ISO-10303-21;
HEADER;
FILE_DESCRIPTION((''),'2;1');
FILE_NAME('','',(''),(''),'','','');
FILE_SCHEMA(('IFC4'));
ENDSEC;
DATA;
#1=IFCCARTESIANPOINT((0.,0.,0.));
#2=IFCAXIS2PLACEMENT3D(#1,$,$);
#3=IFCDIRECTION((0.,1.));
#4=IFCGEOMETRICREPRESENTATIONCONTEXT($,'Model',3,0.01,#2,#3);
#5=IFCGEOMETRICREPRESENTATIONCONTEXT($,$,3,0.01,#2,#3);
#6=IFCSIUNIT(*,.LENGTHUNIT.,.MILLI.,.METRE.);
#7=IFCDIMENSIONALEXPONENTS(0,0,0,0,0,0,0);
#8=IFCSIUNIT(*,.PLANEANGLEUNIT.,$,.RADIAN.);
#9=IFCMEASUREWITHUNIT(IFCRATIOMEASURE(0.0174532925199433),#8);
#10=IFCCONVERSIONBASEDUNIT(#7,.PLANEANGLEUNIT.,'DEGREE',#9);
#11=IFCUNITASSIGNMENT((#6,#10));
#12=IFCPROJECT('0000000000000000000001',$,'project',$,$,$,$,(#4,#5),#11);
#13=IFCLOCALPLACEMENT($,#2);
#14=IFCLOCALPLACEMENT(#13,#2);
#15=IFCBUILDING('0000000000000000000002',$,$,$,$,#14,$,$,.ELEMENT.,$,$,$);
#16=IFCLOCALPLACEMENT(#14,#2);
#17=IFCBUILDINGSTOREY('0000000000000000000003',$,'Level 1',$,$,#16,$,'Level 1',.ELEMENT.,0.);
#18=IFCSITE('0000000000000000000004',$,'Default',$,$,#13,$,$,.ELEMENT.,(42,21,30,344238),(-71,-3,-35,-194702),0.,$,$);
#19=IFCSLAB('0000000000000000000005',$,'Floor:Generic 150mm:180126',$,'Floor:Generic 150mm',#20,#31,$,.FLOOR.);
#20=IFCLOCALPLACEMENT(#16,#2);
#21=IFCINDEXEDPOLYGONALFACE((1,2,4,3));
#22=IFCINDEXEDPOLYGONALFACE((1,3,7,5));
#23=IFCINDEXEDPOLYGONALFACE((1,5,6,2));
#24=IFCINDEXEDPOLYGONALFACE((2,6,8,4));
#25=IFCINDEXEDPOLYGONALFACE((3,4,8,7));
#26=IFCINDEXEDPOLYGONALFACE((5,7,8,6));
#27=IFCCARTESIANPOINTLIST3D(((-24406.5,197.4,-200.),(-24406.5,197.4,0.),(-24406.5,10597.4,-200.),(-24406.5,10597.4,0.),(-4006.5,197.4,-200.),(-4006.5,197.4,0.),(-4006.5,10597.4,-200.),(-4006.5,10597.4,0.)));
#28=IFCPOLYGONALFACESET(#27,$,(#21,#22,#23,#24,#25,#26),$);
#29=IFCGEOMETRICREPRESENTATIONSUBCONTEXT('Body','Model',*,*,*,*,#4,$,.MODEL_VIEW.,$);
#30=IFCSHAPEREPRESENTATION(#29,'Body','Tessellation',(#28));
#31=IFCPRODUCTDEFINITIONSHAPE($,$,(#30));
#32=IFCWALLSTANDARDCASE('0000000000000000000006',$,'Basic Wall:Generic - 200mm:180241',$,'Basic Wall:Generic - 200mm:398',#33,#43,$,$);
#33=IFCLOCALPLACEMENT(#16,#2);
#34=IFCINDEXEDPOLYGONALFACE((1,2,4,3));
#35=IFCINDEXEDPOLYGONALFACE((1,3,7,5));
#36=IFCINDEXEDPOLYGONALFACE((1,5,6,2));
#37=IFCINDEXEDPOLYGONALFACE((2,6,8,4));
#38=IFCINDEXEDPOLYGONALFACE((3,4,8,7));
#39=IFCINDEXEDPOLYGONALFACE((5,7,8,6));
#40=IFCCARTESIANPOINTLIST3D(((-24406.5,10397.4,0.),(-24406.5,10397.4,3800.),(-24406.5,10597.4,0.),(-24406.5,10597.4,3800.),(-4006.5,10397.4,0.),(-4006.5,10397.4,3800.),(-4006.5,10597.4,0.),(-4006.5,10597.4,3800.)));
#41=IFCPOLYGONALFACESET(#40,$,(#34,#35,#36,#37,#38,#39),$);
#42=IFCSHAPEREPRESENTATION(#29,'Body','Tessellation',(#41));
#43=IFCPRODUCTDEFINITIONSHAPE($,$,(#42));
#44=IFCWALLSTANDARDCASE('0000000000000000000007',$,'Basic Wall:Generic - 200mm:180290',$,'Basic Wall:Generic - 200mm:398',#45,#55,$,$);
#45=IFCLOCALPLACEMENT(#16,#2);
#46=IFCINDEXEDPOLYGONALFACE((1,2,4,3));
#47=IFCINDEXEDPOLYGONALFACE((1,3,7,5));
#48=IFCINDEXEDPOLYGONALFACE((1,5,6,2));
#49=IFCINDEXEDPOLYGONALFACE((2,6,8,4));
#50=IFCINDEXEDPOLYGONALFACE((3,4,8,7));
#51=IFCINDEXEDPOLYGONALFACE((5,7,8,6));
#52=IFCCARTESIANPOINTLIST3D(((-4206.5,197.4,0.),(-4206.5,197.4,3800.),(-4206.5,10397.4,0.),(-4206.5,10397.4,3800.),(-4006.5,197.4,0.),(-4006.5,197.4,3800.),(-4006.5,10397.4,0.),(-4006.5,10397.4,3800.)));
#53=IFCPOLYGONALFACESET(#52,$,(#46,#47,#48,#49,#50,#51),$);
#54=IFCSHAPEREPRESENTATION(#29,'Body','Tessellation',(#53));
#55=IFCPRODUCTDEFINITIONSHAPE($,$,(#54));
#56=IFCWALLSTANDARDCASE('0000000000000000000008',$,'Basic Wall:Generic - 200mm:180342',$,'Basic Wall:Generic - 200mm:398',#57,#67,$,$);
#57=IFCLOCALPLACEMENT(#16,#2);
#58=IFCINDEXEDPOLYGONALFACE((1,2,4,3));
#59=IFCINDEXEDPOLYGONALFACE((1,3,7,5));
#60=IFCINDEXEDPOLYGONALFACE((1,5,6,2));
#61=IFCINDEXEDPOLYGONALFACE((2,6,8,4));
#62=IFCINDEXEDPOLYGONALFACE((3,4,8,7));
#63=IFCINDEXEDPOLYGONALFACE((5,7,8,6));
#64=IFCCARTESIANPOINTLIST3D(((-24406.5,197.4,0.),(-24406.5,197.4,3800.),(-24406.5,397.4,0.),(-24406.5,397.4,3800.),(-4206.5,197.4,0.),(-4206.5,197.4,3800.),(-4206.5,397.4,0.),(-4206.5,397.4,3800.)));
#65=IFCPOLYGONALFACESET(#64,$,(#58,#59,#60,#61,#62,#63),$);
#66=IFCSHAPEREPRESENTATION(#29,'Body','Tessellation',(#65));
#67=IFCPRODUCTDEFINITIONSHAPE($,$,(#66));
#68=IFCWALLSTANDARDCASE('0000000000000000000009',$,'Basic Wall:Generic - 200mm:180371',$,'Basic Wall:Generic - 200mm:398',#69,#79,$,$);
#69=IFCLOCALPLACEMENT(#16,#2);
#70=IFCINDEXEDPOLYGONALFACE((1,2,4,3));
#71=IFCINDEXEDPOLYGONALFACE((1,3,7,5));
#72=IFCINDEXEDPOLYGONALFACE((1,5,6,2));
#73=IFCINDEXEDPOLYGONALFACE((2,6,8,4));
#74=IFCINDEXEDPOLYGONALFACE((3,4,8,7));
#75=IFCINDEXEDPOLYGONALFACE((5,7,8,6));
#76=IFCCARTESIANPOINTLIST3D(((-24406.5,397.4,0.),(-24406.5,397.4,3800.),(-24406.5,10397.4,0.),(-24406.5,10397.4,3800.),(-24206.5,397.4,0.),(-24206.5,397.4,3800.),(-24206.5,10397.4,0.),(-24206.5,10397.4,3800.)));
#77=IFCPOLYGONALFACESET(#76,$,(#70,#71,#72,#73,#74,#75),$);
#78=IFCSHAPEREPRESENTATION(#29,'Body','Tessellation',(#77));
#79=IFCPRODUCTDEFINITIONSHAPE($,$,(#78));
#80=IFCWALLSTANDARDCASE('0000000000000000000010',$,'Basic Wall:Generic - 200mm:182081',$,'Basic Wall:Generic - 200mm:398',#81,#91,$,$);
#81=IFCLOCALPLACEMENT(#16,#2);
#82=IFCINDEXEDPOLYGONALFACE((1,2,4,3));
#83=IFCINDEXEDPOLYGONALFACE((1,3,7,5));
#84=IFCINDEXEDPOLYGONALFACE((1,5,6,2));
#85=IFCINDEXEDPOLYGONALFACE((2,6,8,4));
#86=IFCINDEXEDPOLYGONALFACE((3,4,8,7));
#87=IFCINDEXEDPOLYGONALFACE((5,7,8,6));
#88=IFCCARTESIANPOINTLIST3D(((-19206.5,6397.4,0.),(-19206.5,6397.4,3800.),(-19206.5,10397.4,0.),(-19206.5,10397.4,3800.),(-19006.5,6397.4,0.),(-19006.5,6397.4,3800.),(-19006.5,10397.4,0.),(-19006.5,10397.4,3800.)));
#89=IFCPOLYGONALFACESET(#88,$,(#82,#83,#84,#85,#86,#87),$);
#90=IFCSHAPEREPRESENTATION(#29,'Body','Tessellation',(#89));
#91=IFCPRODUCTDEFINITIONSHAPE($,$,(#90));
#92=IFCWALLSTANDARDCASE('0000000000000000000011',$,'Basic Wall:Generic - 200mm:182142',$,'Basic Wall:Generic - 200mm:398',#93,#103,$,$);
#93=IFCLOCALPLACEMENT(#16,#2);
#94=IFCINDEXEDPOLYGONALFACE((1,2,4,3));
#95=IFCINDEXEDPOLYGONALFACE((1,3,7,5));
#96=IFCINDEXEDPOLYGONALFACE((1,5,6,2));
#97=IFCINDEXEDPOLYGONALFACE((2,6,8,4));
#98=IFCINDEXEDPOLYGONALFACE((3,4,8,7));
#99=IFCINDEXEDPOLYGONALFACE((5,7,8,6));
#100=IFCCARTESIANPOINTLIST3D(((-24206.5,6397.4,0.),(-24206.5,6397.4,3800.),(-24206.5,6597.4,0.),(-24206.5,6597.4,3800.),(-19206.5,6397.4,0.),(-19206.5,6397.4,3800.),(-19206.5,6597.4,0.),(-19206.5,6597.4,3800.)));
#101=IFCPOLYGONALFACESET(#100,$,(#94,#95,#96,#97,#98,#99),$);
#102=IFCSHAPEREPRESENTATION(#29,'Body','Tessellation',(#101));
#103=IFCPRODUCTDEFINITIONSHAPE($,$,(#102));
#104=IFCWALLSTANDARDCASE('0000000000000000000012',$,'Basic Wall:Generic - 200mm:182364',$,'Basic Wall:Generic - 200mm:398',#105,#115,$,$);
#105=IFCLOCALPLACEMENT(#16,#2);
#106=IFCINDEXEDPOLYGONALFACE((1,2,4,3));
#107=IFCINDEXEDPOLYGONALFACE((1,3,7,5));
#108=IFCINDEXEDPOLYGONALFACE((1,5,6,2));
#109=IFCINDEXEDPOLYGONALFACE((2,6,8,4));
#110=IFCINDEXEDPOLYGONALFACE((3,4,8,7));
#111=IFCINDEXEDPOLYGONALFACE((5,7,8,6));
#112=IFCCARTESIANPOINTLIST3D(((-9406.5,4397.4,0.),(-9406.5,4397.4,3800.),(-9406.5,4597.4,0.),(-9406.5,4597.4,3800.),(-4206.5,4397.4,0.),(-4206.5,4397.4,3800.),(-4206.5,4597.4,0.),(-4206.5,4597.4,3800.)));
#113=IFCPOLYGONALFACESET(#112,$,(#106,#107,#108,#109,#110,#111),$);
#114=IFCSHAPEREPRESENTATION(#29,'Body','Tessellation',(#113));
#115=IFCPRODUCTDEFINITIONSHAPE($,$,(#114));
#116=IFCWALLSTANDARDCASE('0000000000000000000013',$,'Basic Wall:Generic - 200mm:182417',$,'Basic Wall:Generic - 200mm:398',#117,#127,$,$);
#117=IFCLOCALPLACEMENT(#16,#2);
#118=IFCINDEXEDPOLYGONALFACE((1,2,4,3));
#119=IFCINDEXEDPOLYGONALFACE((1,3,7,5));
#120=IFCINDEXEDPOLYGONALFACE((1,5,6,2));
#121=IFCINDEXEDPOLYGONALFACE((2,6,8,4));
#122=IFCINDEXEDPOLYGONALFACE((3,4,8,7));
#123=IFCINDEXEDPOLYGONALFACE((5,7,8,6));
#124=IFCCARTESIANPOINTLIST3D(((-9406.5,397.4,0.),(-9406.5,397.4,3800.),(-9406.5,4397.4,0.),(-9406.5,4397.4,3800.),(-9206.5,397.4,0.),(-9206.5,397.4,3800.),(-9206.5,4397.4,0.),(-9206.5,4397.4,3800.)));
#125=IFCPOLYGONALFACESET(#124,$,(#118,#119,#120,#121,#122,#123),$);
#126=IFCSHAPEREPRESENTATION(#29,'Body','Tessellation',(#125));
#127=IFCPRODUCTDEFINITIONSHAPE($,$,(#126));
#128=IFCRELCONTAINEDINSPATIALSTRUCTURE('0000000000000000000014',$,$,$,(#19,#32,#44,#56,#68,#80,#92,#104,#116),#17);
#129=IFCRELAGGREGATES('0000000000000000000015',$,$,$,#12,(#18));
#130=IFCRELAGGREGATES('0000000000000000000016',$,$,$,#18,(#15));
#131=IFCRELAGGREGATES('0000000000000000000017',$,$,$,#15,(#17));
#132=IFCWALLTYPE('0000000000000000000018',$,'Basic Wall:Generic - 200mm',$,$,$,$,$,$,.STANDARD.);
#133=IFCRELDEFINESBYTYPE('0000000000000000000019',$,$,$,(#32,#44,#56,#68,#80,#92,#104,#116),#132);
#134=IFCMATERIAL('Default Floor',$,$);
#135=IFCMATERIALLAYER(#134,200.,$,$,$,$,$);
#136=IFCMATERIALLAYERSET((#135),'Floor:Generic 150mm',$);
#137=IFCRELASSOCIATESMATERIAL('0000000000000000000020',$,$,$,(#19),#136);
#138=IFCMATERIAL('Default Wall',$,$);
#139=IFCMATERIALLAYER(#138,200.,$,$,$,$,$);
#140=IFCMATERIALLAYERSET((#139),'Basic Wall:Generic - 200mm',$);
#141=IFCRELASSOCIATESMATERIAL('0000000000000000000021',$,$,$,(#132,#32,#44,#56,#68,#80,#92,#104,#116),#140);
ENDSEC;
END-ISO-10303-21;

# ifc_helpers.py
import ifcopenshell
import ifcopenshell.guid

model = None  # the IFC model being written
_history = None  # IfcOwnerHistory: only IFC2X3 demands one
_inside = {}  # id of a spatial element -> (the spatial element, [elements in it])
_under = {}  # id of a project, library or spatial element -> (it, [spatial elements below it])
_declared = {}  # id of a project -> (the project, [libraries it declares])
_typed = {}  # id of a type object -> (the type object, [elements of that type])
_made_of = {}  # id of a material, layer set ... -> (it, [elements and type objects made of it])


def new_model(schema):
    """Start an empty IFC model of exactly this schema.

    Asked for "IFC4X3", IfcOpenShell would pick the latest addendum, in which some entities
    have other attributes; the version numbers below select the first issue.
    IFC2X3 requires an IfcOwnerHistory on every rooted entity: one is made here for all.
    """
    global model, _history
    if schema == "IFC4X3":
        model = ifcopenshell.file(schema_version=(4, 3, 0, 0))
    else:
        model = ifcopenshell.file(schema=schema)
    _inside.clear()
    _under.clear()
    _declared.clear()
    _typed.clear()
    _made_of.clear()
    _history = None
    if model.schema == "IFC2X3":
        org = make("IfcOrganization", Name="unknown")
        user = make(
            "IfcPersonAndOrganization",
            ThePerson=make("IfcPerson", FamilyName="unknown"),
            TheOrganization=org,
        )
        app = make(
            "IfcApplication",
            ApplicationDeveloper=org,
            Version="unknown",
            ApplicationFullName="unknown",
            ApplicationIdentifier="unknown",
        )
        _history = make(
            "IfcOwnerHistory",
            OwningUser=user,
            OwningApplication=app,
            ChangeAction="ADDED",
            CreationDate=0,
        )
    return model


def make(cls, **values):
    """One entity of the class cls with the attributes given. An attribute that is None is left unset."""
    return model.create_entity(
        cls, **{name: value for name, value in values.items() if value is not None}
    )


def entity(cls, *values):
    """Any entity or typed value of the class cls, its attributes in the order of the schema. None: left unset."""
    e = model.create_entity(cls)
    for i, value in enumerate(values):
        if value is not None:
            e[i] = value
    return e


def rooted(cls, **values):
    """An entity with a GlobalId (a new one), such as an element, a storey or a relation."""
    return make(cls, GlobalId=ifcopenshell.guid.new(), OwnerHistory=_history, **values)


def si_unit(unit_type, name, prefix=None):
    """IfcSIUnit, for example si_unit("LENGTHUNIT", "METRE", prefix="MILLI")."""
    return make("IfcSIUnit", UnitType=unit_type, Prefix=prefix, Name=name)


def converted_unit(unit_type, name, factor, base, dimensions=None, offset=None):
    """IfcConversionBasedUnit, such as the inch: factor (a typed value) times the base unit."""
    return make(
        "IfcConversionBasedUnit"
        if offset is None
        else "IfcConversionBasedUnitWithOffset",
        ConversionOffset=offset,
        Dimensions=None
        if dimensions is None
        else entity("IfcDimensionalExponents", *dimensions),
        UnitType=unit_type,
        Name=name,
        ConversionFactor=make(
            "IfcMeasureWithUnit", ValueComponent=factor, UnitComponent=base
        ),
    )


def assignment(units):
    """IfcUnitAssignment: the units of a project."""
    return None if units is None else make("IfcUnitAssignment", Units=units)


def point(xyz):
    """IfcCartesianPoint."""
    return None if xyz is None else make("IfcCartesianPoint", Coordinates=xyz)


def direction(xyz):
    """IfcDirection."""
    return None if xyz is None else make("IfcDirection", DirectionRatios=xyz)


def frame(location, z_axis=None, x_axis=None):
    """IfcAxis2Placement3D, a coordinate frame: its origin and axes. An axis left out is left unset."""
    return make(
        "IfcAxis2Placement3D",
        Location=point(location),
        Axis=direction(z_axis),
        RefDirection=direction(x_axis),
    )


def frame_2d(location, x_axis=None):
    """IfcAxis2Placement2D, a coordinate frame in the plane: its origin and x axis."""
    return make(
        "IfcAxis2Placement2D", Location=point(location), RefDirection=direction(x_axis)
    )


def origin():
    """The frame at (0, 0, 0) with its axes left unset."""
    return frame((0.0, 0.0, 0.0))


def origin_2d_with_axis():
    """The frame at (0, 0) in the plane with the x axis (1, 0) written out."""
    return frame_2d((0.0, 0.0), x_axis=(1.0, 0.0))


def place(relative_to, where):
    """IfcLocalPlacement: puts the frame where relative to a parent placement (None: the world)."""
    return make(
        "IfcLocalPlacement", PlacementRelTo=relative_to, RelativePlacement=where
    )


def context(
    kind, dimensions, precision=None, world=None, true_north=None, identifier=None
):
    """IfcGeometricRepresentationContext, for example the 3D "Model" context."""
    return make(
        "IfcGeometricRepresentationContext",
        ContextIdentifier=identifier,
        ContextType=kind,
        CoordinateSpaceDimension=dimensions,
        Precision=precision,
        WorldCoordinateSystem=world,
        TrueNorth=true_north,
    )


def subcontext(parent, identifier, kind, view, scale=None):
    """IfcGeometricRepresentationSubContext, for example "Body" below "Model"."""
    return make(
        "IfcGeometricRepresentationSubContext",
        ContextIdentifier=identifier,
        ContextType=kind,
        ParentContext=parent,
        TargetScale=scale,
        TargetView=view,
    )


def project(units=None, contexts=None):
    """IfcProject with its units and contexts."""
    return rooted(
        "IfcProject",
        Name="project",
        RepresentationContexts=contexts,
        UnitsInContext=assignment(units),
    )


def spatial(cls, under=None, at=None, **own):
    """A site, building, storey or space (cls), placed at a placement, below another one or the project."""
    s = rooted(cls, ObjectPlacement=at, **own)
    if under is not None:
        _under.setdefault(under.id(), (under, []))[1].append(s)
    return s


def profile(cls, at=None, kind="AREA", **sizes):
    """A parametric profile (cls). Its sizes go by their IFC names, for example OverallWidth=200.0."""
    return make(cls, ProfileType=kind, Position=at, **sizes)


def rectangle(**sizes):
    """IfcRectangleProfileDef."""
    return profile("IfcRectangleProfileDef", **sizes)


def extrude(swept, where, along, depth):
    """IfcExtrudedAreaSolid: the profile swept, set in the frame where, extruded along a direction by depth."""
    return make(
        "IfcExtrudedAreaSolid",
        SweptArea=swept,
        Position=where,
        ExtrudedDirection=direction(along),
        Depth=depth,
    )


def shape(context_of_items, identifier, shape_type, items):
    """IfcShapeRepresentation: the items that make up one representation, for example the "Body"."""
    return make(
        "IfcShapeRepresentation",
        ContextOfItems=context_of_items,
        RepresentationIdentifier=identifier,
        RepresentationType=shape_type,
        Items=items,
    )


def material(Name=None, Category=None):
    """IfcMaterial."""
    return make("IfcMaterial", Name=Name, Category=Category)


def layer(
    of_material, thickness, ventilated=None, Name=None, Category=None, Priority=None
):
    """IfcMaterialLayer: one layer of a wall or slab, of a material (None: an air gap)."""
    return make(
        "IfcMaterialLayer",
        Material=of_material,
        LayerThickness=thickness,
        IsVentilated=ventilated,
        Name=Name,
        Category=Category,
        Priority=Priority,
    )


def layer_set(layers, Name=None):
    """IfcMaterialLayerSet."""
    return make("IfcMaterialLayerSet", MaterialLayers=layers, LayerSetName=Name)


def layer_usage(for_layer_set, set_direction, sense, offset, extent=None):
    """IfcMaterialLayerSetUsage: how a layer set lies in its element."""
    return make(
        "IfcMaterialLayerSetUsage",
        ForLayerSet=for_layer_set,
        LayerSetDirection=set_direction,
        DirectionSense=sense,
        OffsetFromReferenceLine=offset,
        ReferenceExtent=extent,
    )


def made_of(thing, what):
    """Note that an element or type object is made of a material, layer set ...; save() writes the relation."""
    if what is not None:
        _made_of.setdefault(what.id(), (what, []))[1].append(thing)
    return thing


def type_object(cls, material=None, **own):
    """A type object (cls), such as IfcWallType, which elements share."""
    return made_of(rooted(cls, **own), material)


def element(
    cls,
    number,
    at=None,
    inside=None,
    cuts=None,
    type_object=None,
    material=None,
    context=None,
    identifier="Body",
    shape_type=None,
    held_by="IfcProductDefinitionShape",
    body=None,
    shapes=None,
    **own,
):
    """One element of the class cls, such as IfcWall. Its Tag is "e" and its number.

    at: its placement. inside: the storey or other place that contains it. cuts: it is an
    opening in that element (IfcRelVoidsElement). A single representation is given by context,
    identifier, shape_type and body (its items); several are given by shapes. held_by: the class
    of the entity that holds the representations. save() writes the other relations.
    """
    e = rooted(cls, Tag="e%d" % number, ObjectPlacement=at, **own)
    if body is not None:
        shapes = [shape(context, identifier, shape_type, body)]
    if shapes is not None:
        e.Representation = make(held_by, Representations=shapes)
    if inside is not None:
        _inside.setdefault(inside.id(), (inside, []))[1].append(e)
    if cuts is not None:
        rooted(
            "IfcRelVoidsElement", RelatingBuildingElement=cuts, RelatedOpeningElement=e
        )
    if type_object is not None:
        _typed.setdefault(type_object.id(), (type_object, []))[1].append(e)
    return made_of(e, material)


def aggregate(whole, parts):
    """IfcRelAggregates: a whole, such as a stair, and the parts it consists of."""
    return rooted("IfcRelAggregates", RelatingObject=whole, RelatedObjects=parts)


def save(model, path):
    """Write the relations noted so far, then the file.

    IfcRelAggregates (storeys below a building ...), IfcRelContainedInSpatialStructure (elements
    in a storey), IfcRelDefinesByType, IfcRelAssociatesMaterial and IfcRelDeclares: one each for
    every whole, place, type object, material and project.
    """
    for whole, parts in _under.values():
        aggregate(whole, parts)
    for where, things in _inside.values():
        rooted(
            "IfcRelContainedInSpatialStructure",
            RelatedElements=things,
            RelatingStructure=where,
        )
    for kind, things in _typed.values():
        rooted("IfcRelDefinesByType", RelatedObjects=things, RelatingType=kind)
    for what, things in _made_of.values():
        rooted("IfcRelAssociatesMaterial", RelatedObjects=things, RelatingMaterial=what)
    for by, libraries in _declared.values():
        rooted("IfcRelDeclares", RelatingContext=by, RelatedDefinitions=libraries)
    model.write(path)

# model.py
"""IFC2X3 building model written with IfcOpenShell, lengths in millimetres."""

from ifc_helpers import new_model, entity, si_unit, converted_unit, direction, frame, frame_2d, origin, origin_2d_with_axis, place, context, subcontext, project, spatial, rectangle, extrude, material, layer, layer_set, layer_usage, type_object, element, save


model = new_model("IFC2X3")

# Units and contexts
model_context = context("Model", 3, precision=0.01, world=origin(), true_north=direction((0.0, 1.0)))
context_of_model = context(None, 3, precision=0.01, world=origin(), true_north=direction((0.0, 1.0)))
body_context = subcontext(model_context, "Body", "Model", "MODEL_VIEW")
ifc_project = project(units=[si_unit("LENGTHUNIT", "METRE", prefix="MILLI"), converted_unit("PLANEANGLEUNIT", "DEGREE", entity("IfcRatioMeasure", 0.0174532925199433), si_unit("PLANEANGLEUNIT", "RADIAN"), dimensions=[0, 0, 0, 0, 0, 0, 0])], contexts=[model_context, context_of_model])

# Site, building, storey
site_placement = place(None, origin())
site = spatial("IfcSite", under=ifc_project, at=site_placement, Name="Default", CompositionType="ELEMENT", RefLatitude=(42, 21, 30, 344238), RefLongitude=(-71, -3, -35, -194702), RefElevation=0.0)
building_placement = place(site_placement, origin())
building = spatial("IfcBuilding", under=site, at=building_placement, CompositionType="ELEMENT")
storey_placement = place(building_placement, origin())
storey = spatial("IfcBuildingStorey", under=building, at=storey_placement, Name="Level 1", LongName="Level 1", CompositionType="ELEMENT", Elevation=0.0)

# Slab
ifc_material_1 = material(Name="Default Floor")
ifc_layer_1 = layer(ifc_material_1, 200.0)
ifc_layer_set_1 = layer_set([ifc_layer_1], Name="Floor:Generic 150mm")
ifc_layer_usage_1 = layer_usage(ifc_layer_set_1, "AXIS3", "POSITIVE", 0.0)
slab_placement = place(storey_placement, origin())
element("IfcSlab", 1, at=slab_placement, inside=storey, material=ifc_layer_usage_1, Name="Floor:Generic 150mm:180126", ObjectType="Floor:Generic 150mm", PredefinedType="FLOOR", context=body_context, shape_type="SweptSolid", body=[
    extrude(rectangle(XDim=10400.0, YDim=20400.0, at=origin_2d_with_axis()), frame((-14206.5, 5397.4, 0.0), z_axis=(0.0, 0.0, -1.0), x_axis=(0.0, 1.0, 0.0)), (0.0, 0.0, 1.0), 200.0),
])

# Walls
ifc_material_2 = material(Name="Default Wall")
ifc_layer_2 = layer(ifc_material_2, 200.0)
ifc_layer_set_2 = layer_set([ifc_layer_2], Name="Basic Wall:Generic - 200mm")
ifc_layer_usage_2 = layer_usage(ifc_layer_set_2, "AXIS2", "NEGATIVE", 100.0)
wall_type = type_object("IfcWallType", Name="Basic Wall:Generic - 200mm", PredefinedType="STANDARD", material=ifc_layer_set_2)
wall_1_placement = place(storey_placement, frame((-24406.5, 10497.4, 0.0)))
element("IfcWallStandardCase", 2, at=wall_1_placement, inside=storey, type_object=wall_type, material=ifc_layer_usage_2, Name="Basic Wall:Generic - 200mm:180241", ObjectType="Basic Wall:Generic - 200mm:398", context=body_context, shape_type="SweptSolid", body=[
    extrude(rectangle(XDim=20400.0, YDim=200.0, at=frame_2d((10200.0, 0.0), x_axis=(-1.0, 0.0))), origin(), (0.0, 0.0, 1.0), 3800.0),
])
ifc_layer_usage_3 = layer_usage(ifc_layer_set_2, "AXIS2", "NEGATIVE", 100.0)
wall_2_placement = place(storey_placement, frame((-4106.5, 10397.4, 0.0), z_axis=(0.0, 0.0, 1.0), x_axis=(0.0, -1.0, 0.0)))
element("IfcWallStandardCase", 3, at=wall_2_placement, inside=storey, type_object=wall_type, material=ifc_layer_usage_3, Name="Basic Wall:Generic - 200mm:180290", ObjectType="Basic Wall:Generic - 200mm:398", context=body_context, shape_type="SweptSolid", body=[
    extrude(rectangle(XDim=10200.0, YDim=200.0, at=frame_2d((5100.0, 0.0), x_axis=(-1.0, 0.0))), origin(), (0.0, 0.0, 1.0), 3800.0),
])
ifc_layer_usage_4 = layer_usage(ifc_layer_set_2, "AXIS2", "NEGATIVE", 100.0)
wall_3_placement = place(storey_placement, frame((-4206.5, 297.4, 0.0), z_axis=(0.0, 0.0, 1.0), x_axis=(-1.0, 0.0, 0.0)))
element("IfcWallStandardCase", 4, at=wall_3_placement, inside=storey, type_object=wall_type, material=ifc_layer_usage_4, Name="Basic Wall:Generic - 200mm:180342", ObjectType="Basic Wall:Generic - 200mm:398", context=body_context, shape_type="SweptSolid", body=[
    extrude(rectangle(XDim=20200.0, YDim=200.0, at=frame_2d((10100.0, 0.0), x_axis=(-1.0, 0.0))), origin(), (0.0, 0.0, 1.0), 3800.0),
])
ifc_layer_usage_5 = layer_usage(ifc_layer_set_2, "AXIS2", "NEGATIVE", 100.0)
wall_4_placement = place(storey_placement, frame((-24306.5, 397.4, 0.0), z_axis=(0.0, 0.0, 1.0), x_axis=(0.0, 1.0, 0.0)))
element("IfcWallStandardCase", 5, at=wall_4_placement, inside=storey, type_object=wall_type, material=ifc_layer_usage_5, Name="Basic Wall:Generic - 200mm:180371", ObjectType="Basic Wall:Generic - 200mm:398", context=body_context, shape_type="SweptSolid", body=[
    extrude(rectangle(XDim=10000.0, YDim=200.0, at=frame_2d((5000.0, 0.0), x_axis=(-1.0, 0.0))), origin(), (0.0, 0.0, 1.0), 3800.0),
])
ifc_layer_usage_6 = layer_usage(ifc_layer_set_2, "AXIS2", "NEGATIVE", 100.0)
wall_5_placement = place(storey_placement, frame((-19106.5, 10397.4, 0.0), z_axis=(0.0, 0.0, 1.0), x_axis=(0.0, -1.0, 0.0)))
element("IfcWallStandardCase", 6, at=wall_5_placement, inside=storey, type_object=wall_type, material=ifc_layer_usage_6, Name="Basic Wall:Generic - 200mm:182081", ObjectType="Basic Wall:Generic - 200mm:398", context=body_context, shape_type="SweptSolid", body=[
    extrude(rectangle(XDim=4000.0, YDim=200.0, at=frame_2d((2000.0, 0.0), x_axis=(-1.0, 0.0))), origin(), (0.0, 0.0, 1.0), 3800.0),
])
ifc_layer_usage_7 = layer_usage(ifc_layer_set_2, "AXIS2", "NEGATIVE", 100.0)
wall_6_placement = place(storey_placement, frame((-19206.5, 6497.4, 0.0), z_axis=(0.0, 0.0, 1.0), x_axis=(-1.0, 0.0, 0.0)))
element("IfcWallStandardCase", 7, at=wall_6_placement, inside=storey, type_object=wall_type, material=ifc_layer_usage_7, Name="Basic Wall:Generic - 200mm:182142", ObjectType="Basic Wall:Generic - 200mm:398", context=body_context, shape_type="SweptSolid", body=[
    extrude(rectangle(XDim=5000.0, YDim=200.0, at=frame_2d((2500.0, 0.0), x_axis=(-1.0, 0.0))), origin(), (0.0, 0.0, 1.0), 3800.0),
])
ifc_layer_usage_8 = layer_usage(ifc_layer_set_2, "AXIS2", "NEGATIVE", 100.0)
wall_7_placement = place(storey_placement, frame((-4206.5, 4497.4, 0.0), z_axis=(0.0, 0.0, 1.0), x_axis=(-1.0, 0.0, 0.0)))
element("IfcWallStandardCase", 8, at=wall_7_placement, inside=storey, type_object=wall_type, material=ifc_layer_usage_8, Name="Basic Wall:Generic - 200mm:182364", ObjectType="Basic Wall:Generic - 200mm:398", context=body_context, shape_type="SweptSolid", body=[
    extrude(rectangle(XDim=5200.0, YDim=200.0, at=frame_2d((2600.0, 0.0), x_axis=(-1.0, 0.0))), origin(), (0.0, 0.0, 1.0), 3800.0),
])
ifc_layer_usage_9 = layer_usage(ifc_layer_set_2, "AXIS2", "NEGATIVE", 100.0)
wall_8_placement = place(storey_placement, frame((-9306.5, 4397.4, 0.0), z_axis=(0.0, 0.0, 1.0), x_axis=(0.0, -1.0, 0.0)))
element("IfcWallStandardCase", 9, at=wall_8_placement, inside=storey, type_object=wall_type, material=ifc_layer_usage_9, Name="Basic Wall:Generic - 200mm:182417", ObjectType="Basic Wall:Generic - 200mm:398", context=body_context, shape_type="SweptSolid", body=[
    extrude(rectangle(XDim=4000.0, YDim=200.0, at=frame_2d((2000.0, 0.0), x_axis=(-1.0, 0.0))), origin(), (0.0, 0.0, 1.0), 3800.0),
])

save(model, "model.ifc")
